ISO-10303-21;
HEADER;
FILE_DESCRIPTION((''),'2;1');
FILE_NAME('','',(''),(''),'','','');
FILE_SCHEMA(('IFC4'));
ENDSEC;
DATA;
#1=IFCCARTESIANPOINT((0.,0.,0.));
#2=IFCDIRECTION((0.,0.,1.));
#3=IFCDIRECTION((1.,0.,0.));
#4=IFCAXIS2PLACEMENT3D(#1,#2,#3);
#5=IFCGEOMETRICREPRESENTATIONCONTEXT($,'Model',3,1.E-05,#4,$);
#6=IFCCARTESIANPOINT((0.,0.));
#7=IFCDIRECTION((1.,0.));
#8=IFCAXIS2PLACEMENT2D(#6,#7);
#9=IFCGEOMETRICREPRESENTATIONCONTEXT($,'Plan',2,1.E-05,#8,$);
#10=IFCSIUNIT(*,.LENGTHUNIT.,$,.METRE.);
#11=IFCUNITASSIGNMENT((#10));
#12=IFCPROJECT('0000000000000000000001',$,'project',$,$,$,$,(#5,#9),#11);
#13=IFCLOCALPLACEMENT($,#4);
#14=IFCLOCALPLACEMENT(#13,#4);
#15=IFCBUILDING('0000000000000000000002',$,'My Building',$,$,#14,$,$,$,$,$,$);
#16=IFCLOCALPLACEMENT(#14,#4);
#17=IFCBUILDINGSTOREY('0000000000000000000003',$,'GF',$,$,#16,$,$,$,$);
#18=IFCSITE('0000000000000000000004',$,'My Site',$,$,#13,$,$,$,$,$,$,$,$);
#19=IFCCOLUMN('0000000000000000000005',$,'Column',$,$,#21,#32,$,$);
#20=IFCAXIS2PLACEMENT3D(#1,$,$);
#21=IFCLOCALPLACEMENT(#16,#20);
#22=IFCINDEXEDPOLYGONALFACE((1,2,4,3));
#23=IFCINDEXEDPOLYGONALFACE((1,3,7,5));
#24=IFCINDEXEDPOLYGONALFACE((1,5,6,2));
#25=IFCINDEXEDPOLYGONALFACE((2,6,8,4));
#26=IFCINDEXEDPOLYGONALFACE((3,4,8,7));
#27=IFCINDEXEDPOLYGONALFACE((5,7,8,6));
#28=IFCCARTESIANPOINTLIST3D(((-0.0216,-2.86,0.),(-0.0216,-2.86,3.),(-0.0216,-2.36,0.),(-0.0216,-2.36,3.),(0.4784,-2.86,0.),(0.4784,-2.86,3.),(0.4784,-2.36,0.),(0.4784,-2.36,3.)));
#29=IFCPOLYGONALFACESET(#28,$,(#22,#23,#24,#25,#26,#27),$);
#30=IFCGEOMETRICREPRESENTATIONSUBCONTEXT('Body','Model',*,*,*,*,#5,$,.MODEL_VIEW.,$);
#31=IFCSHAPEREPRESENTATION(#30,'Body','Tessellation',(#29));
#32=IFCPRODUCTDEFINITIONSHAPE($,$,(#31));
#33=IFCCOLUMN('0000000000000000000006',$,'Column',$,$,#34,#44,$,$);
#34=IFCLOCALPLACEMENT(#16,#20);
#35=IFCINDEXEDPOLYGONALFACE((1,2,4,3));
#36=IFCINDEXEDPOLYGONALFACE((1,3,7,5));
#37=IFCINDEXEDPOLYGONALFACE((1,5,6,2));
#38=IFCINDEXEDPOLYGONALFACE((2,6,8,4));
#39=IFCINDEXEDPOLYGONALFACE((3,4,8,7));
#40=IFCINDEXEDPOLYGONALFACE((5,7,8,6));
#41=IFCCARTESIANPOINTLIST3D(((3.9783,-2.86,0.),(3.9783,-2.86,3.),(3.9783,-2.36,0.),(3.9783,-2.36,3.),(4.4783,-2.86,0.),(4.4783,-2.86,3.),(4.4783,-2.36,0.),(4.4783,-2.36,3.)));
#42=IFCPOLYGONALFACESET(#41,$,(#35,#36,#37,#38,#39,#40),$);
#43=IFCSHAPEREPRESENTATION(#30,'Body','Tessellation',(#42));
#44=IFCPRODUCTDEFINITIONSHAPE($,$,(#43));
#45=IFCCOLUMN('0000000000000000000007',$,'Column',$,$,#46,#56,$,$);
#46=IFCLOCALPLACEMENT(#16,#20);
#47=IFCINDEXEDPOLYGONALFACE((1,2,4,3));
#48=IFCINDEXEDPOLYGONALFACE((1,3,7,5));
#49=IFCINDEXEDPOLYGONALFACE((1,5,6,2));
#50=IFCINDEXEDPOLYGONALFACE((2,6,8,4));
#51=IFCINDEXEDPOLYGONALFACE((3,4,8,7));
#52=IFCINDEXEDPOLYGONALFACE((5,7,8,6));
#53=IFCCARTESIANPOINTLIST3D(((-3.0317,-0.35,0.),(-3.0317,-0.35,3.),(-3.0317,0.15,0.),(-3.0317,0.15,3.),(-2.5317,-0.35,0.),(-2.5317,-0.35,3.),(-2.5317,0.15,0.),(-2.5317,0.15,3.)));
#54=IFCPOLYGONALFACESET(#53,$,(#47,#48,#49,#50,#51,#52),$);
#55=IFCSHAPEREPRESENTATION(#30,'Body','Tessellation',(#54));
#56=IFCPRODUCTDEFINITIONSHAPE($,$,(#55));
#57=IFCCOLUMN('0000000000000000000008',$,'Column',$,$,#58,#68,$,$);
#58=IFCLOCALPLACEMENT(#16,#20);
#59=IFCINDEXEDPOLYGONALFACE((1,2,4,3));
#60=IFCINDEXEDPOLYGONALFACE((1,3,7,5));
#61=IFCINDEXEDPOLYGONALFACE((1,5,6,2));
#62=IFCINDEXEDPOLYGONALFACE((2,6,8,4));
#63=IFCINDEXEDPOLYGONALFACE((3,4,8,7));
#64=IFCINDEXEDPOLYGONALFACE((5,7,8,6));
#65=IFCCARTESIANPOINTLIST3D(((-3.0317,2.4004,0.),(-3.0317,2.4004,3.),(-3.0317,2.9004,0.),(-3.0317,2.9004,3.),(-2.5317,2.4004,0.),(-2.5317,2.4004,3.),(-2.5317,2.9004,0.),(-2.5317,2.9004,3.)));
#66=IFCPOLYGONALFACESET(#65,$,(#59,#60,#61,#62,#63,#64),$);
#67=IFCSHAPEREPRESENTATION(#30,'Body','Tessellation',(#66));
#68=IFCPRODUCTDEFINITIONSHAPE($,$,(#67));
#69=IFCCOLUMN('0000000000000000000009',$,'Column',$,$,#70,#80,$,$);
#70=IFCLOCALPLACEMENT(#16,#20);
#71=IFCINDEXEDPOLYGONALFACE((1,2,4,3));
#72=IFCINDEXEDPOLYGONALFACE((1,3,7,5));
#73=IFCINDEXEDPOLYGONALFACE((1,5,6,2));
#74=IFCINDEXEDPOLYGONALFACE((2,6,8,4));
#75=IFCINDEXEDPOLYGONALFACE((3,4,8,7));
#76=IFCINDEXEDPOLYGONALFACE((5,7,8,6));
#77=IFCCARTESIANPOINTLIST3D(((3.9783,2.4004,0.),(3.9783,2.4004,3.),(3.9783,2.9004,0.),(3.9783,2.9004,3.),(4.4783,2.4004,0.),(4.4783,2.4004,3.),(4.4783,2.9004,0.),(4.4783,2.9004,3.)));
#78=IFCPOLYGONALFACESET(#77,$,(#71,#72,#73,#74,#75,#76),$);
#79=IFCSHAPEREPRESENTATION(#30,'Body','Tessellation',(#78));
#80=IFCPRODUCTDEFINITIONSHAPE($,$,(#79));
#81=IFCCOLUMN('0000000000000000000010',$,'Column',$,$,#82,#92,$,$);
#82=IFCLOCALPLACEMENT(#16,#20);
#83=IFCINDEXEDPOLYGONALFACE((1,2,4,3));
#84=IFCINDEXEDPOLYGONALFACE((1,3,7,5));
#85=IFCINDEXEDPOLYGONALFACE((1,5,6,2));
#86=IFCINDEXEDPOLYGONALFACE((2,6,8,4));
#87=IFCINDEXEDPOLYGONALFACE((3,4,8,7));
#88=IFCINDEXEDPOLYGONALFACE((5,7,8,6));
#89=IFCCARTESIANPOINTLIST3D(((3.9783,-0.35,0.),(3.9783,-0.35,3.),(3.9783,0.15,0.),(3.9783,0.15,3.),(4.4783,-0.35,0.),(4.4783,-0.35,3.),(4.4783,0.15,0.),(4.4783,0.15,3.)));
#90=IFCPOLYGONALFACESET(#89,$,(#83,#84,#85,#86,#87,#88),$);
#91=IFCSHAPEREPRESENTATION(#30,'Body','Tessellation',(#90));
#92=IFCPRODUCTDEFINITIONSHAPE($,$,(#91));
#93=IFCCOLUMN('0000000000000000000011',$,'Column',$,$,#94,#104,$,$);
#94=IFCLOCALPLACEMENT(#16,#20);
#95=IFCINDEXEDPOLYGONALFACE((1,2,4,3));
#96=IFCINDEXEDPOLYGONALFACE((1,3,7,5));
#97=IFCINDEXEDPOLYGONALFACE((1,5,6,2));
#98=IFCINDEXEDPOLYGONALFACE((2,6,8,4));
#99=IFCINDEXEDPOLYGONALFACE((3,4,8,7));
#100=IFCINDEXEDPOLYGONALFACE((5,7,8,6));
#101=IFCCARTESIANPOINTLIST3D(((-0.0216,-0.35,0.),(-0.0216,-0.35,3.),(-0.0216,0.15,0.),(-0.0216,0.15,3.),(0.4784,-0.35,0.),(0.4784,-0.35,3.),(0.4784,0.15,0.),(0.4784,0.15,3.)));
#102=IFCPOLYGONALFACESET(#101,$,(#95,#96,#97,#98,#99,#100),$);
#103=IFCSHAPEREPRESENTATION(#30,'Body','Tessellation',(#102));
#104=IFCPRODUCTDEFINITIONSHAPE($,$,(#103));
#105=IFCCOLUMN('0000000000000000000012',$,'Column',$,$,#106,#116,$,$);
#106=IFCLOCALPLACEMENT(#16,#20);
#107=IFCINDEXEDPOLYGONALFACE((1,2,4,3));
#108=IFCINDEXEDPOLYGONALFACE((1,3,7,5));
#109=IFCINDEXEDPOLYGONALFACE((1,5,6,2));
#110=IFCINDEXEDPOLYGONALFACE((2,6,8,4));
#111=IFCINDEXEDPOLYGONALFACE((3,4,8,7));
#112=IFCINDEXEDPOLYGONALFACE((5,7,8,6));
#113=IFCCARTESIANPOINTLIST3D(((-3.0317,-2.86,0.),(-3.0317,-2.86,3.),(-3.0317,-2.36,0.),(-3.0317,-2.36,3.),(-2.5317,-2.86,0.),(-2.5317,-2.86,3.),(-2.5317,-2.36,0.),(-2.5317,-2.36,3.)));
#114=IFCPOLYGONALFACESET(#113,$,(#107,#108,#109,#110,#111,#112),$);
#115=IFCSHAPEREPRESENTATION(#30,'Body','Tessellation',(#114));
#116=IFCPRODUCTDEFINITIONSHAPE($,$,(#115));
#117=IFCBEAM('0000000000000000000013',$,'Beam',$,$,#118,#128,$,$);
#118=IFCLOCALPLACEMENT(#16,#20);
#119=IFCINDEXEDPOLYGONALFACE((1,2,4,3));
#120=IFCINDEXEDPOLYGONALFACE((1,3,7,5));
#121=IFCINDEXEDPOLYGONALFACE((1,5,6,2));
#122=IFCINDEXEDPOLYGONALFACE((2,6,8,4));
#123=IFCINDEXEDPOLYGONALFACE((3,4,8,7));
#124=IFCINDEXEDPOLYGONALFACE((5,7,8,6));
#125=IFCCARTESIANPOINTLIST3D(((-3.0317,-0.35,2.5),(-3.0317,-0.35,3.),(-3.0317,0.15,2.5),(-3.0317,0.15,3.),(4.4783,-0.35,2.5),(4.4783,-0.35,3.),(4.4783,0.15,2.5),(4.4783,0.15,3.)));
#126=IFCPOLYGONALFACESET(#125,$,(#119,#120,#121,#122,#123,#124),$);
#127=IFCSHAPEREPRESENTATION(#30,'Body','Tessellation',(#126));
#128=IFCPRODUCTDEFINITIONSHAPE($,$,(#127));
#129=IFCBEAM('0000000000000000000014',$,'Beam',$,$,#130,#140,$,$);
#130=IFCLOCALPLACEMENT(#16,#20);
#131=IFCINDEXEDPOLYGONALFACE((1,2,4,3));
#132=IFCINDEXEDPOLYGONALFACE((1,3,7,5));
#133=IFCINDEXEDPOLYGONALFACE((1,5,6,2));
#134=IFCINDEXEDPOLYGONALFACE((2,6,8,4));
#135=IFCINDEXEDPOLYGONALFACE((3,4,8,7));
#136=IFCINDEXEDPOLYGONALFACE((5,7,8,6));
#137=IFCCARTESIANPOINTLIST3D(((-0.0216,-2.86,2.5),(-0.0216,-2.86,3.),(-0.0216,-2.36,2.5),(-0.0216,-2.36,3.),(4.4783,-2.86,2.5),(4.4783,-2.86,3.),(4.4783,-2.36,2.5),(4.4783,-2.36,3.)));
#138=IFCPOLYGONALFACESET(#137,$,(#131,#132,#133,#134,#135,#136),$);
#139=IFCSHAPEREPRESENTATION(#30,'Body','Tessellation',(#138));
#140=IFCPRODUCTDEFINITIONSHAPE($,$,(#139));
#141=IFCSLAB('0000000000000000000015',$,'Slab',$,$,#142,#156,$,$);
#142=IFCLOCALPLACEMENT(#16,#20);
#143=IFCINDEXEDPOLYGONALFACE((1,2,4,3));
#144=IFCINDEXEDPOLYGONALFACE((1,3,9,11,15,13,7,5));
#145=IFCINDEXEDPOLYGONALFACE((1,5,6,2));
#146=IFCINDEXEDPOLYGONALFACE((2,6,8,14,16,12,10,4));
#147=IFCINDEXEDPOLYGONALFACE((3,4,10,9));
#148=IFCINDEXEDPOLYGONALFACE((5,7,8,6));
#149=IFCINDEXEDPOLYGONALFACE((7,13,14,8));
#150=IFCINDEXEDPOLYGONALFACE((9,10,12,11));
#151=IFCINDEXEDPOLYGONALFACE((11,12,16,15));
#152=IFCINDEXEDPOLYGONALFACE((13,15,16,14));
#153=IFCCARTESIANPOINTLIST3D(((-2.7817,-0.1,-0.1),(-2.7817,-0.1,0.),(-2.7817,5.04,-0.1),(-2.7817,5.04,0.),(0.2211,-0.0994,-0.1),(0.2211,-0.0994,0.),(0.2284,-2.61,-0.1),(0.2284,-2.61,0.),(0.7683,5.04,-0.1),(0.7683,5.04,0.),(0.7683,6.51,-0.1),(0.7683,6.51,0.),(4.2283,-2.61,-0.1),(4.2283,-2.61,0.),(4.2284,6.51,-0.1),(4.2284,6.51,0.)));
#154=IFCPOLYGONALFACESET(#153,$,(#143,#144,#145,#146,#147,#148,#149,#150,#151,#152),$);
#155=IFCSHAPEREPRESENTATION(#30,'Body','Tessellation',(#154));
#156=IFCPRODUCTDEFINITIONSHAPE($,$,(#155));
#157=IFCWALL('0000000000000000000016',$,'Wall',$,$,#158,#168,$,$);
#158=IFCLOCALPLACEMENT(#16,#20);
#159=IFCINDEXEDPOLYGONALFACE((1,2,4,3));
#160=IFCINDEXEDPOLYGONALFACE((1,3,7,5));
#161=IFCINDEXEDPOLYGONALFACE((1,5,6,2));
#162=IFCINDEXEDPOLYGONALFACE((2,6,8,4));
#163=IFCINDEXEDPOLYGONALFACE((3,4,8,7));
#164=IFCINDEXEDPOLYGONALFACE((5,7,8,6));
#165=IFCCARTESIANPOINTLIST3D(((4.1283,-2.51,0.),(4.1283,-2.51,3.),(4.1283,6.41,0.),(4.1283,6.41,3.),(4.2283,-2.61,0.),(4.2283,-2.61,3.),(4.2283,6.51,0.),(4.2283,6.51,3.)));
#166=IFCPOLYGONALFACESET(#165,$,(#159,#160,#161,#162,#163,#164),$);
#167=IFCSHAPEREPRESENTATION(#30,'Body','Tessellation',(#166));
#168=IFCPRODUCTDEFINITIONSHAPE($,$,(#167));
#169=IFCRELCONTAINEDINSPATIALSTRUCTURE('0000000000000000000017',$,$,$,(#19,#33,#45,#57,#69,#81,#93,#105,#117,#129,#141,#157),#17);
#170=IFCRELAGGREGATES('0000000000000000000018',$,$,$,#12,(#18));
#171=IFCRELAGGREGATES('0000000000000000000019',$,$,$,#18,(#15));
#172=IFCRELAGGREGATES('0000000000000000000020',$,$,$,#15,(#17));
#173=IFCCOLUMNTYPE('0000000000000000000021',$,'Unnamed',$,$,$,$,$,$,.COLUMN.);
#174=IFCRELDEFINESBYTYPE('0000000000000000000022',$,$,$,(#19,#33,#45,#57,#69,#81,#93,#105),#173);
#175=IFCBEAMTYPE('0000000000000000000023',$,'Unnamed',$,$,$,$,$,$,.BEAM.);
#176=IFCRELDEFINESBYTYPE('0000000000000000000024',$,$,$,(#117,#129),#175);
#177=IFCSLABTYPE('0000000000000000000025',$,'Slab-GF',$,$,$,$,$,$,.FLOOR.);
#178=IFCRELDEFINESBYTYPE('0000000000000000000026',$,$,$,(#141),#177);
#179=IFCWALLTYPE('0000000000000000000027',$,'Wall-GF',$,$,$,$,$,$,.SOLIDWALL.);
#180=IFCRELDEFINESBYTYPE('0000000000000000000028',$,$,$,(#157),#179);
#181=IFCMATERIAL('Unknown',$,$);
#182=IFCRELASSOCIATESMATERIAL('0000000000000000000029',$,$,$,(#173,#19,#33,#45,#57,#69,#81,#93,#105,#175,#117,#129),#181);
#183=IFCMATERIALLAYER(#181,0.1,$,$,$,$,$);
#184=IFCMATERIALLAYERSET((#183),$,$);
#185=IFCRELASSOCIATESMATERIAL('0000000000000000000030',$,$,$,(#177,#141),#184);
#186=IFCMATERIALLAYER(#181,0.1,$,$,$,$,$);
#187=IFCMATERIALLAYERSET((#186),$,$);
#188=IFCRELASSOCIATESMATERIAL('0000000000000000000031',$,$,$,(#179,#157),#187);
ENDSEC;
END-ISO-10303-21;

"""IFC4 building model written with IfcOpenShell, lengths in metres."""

from ifc_helpers import new_model, si_unit, frame, origin_with_axes, origin_2d_with_axis, place, context, subcontext, project, spatial, line, indexed_curve, rectangle, outline, extrude, material, layer, layer_set, layer_usage, material_profile, profile_set, profile_usage, type_object, element, save


model = new_model("IFC4")

# Units and contexts
model_context = context("Model", 3, precision=1e-05, world=origin_with_axes())
plan_context = context("Plan", 2, precision=1e-05, world=origin_2d_with_axis())
body_context_1 = subcontext(model_context, "Body", "Model", "MODEL_VIEW")
ifc_project = project(units=[si_unit("LENGTHUNIT", "METRE")], contexts=[model_context, plan_context])

# Site, building, storey
site_placement = place(None, origin_with_axes())
site = spatial("IfcSite", under=ifc_project, at=site_placement, Name="My Site")
building_placement = place(site_placement, origin_with_axes())
building = spatial("IfcBuilding", under=site, at=building_placement, Name="My Building")
storey_placement = place(building_placement, origin_with_axes())
storey = spatial("IfcBuildingStorey", under=building, at=storey_placement, Name="GF")

# Columns
ifc_material = material(Name="Unknown")
ifc_material_profile_1 = material_profile(ifc_material, rectangle(XDim=0.5, YDim=0.5))
ifc_profile_set_1 = profile_set([ifc_material_profile_1])
ifc_profile_usage_1 = profile_usage(ifc_profile_set_1, cardinal=5)
column_type = type_object("IfcColumnType", Name="Unnamed", PredefinedType="COLUMN", material=ifc_profile_set_1)
column_1_placement = place(storey_placement, frame((0.2284, -2.61, 0.0), z_axis=(0.0, 0.0, 1.0), x_axis=(1.0, 0.0, 0.0)))
element("IfcColumn", 1, at=column_1_placement, inside=storey, type_object=column_type, material=ifc_profile_usage_1, Name="Column", context=body_context_1, shape_type="SweptSolid", body=[
    extrude(rectangle(XDim=0.5, YDim=0.5), origin_with_axes(), (0.0, 0.0, 1.0), 3.0),
])
ifc_profile_usage_2 = profile_usage(ifc_profile_set_1, cardinal=5)
column_2_placement = place(storey_placement, frame((4.2283, -2.61, 0.0), z_axis=(0.0, 0.0, 1.0), x_axis=(1.0, 0.0, 0.0)))
element("IfcColumn", 2, at=column_2_placement, inside=storey, type_object=column_type, material=ifc_profile_usage_2, Name="Column", context=body_context_1, shape_type="SweptSolid", body=[
    extrude(rectangle(XDim=0.5, YDim=0.5), origin_with_axes(), (0.0, 0.0, 1.0), 3.0),
])
ifc_profile_usage_3 = profile_usage(ifc_profile_set_1, cardinal=5)
column_3_placement = place(storey_placement, frame((-2.7817, -0.1, 0.0), z_axis=(0.0, 0.0, 1.0), x_axis=(1.0, 0.0, 0.0)))
element("IfcColumn", 3, at=column_3_placement, inside=storey, type_object=column_type, material=ifc_profile_usage_3, Name="Column", context=body_context_1, shape_type="SweptSolid", body=[
    extrude(rectangle(XDim=0.5, YDim=0.5), origin_with_axes(), (0.0, 0.0, 1.0), 3.0),
])
ifc_profile_usage_4 = profile_usage(ifc_profile_set_1, cardinal=5)
column_4_placement = place(storey_placement, frame((-2.7817, 2.6504, 0.0), z_axis=(0.0, 0.0, 1.0), x_axis=(1.0, 0.0, 0.0)))
element("IfcColumn", 4, at=column_4_placement, inside=storey, type_object=column_type, material=ifc_profile_usage_4, Name="Column", context=body_context_1, shape_type="SweptSolid", body=[
    extrude(rectangle(XDim=0.5, YDim=0.5), origin_with_axes(), (0.0, 0.0, 1.0), 3.0),
])
ifc_profile_usage_5 = profile_usage(ifc_profile_set_1, cardinal=5)
column_5_placement = place(storey_placement, frame((4.2283, 2.6504, 0.0), z_axis=(0.0, 0.0, 1.0), x_axis=(1.0, 0.0, 0.0)))
element("IfcColumn", 5, at=column_5_placement, inside=storey, type_object=column_type, material=ifc_profile_usage_5, Name="Column", context=body_context_1, shape_type="SweptSolid", body=[
    extrude(rectangle(XDim=0.5, YDim=0.5), origin_with_axes(), (0.0, 0.0, 1.0), 3.0),
])
ifc_profile_usage_6 = profile_usage(ifc_profile_set_1, cardinal=5)
column_6_placement = place(storey_placement, frame((4.2283, -0.1, 0.0), z_axis=(0.0, 0.0, 1.0), x_axis=(1.0, 0.0, 0.0)))
element("IfcColumn", 6, at=column_6_placement, inside=storey, type_object=column_type, material=ifc_profile_usage_6, Name="Column", context=body_context_1, shape_type="SweptSolid", body=[
    extrude(rectangle(XDim=0.5, YDim=0.5), origin_with_axes(), (0.0, 0.0, 1.0), 3.0),
])
ifc_profile_usage_7 = profile_usage(ifc_profile_set_1, cardinal=5)
column_7_placement = place(storey_placement, frame((0.2284, -0.1, 0.0), z_axis=(0.0, 0.0, 1.0), x_axis=(1.0, 0.0, 0.0)))
element("IfcColumn", 7, at=column_7_placement, inside=storey, type_object=column_type, material=ifc_profile_usage_7, Name="Column", context=body_context_1, shape_type="SweptSolid", body=[
    extrude(rectangle(XDim=0.5, YDim=0.5), origin_with_axes(), (0.0, 0.0, 1.0), 3.0),
])
ifc_profile_usage_8 = profile_usage(ifc_profile_set_1, cardinal=5)
column_8_placement = place(storey_placement, frame((-2.7817, -2.61, 0.0), z_axis=(0.0, 0.0, 1.0), x_axis=(1.0, 0.0, 0.0)))
element("IfcColumn", 8, at=column_8_placement, inside=storey, type_object=column_type, material=ifc_profile_usage_8, Name="Column", context=body_context_1, shape_type="SweptSolid", body=[
    extrude(rectangle(XDim=0.5, YDim=0.5), origin_with_axes(), (0.0, 0.0, 1.0), 3.0),
])

# Beams
ifc_material_profile_2 = material_profile(ifc_material, rectangle(XDim=0.5, YDim=0.5))
ifc_profile_set_2 = profile_set([ifc_material_profile_2])
ifc_profile_usage_9 = profile_usage(ifc_profile_set_2, cardinal=7)
beam_type = type_object("IfcBeamType", Name="Unnamed", PredefinedType="BEAM", material=ifc_profile_set_2)
beam_1_placement = place(storey_placement, frame((4.4783, -0.35, 3.0), z_axis=(-1.0, 0.0, 0.0), x_axis=(0.0, -1.0, 0.0)))
element("IfcBeam", 9, at=beam_1_placement, inside=storey, type_object=beam_type, material=ifc_profile_usage_9, Name="Beam", context=body_context_1, shape_type="SweptSolid", body=[
    extrude(rectangle(XDim=0.5, YDim=0.5), frame((-0.25, -0.25, 0.0), z_axis=(0.0, 0.0, 1.0), x_axis=(1.0, 0.0, 0.0)), (0.0, 0.0, 1.0), 7.51),
])
ifc_profile_usage_10 = profile_usage(ifc_profile_set_2, cardinal=7)
beam_2_placement = place(storey_placement, frame((4.4783, -2.86, 3.0), z_axis=(-1.0, 0.0, 0.0), x_axis=(0.0, -1.0, 0.0)))
element("IfcBeam", 10, at=beam_2_placement, inside=storey, type_object=beam_type, material=ifc_profile_usage_10, Name="Beam", context=body_context_1, shape_type="SweptSolid", body=[
    extrude(rectangle(XDim=0.5, YDim=0.5), frame((-0.25, -0.25, 0.0), z_axis=(0.0, 0.0, 1.0), x_axis=(1.0, 0.0, 0.0)), (0.0, 0.0, 1.0), 4.5),
])

# Slab
ifc_layer_1 = layer(ifc_material, 0.1)
ifc_layer_set_1 = layer_set([ifc_layer_1])
ifc_layer_usage_1 = layer_usage(ifc_layer_set_1, "AXIS3", "POSITIVE", -0.1)
slab_type_1 = type_object("IfcSlabType", Name="Slab-GF", PredefinedType="FLOOR", material=ifc_layer_set_1)
slab_1_placement = place(storey_placement, frame((4.2283, -2.61, 0.0), z_axis=(0.0, 0.0, 1.0), x_axis=(1.0, 0.0, 0.0)))
element("IfcSlab", 11, at=slab_1_placement, inside=storey, type_object=slab_type_1, material=ifc_layer_usage_1, Name="Slab", context=body_context_1, shape_type="SweptSolid", body=[
    extrude(outline(indexed_curve([(0.0, 0.0), (0.0, 9.12), (-3.46, 9.12), (-3.46, 7.65), (-7.01, 7.65), (-7.01, 2.51), (-4.0073, 2.5106), (-4.0, 0.0), (0.0, 0.0)])), frame((0.0, 0.0, -0.1), z_axis=(0.0, 0.0, 1.0), x_axis=(1.0, 0.0, 0.0)), (0.0, 0.0, 1.0), 0.1),
])

# Shared definitions
ifc_layer_2 = layer(ifc_material, 0.1)
ifc_layer_set_2 = layer_set([ifc_layer_2])
wall_type = type_object("IfcWallType", Name="Wall-GF", PredefinedType="SOLIDWALL", material=ifc_layer_set_2)

# Wall
ifc_layer_usage_2 = layer_usage(ifc_layer_set_2, "AXIS2", "POSITIVE", 0.0)
wall_1_placement = place(storey_placement, frame((4.2283, -2.61, 0.0), z_axis=(0.0, 0.0, 1.0), x_axis=(0.0, 1.0, 0.0)))
element("IfcWall", 12, at=wall_1_placement, inside=storey, type_object=wall_type, material=ifc_layer_usage_2, Name="Wall", context=body_context_1, shape_type="SweptSolid", body=[
    extrude(outline(indexed_curve([(0.0, 0.0), (0.1, 0.1), (9.02, 0.1), (9.12, 0.0)], segments=[line(1, 2, 3, 4, 1)])), origin_with_axes(), (0.0, 0.0, 1.0), 3.0),
])

save(model, "model.ifc")
